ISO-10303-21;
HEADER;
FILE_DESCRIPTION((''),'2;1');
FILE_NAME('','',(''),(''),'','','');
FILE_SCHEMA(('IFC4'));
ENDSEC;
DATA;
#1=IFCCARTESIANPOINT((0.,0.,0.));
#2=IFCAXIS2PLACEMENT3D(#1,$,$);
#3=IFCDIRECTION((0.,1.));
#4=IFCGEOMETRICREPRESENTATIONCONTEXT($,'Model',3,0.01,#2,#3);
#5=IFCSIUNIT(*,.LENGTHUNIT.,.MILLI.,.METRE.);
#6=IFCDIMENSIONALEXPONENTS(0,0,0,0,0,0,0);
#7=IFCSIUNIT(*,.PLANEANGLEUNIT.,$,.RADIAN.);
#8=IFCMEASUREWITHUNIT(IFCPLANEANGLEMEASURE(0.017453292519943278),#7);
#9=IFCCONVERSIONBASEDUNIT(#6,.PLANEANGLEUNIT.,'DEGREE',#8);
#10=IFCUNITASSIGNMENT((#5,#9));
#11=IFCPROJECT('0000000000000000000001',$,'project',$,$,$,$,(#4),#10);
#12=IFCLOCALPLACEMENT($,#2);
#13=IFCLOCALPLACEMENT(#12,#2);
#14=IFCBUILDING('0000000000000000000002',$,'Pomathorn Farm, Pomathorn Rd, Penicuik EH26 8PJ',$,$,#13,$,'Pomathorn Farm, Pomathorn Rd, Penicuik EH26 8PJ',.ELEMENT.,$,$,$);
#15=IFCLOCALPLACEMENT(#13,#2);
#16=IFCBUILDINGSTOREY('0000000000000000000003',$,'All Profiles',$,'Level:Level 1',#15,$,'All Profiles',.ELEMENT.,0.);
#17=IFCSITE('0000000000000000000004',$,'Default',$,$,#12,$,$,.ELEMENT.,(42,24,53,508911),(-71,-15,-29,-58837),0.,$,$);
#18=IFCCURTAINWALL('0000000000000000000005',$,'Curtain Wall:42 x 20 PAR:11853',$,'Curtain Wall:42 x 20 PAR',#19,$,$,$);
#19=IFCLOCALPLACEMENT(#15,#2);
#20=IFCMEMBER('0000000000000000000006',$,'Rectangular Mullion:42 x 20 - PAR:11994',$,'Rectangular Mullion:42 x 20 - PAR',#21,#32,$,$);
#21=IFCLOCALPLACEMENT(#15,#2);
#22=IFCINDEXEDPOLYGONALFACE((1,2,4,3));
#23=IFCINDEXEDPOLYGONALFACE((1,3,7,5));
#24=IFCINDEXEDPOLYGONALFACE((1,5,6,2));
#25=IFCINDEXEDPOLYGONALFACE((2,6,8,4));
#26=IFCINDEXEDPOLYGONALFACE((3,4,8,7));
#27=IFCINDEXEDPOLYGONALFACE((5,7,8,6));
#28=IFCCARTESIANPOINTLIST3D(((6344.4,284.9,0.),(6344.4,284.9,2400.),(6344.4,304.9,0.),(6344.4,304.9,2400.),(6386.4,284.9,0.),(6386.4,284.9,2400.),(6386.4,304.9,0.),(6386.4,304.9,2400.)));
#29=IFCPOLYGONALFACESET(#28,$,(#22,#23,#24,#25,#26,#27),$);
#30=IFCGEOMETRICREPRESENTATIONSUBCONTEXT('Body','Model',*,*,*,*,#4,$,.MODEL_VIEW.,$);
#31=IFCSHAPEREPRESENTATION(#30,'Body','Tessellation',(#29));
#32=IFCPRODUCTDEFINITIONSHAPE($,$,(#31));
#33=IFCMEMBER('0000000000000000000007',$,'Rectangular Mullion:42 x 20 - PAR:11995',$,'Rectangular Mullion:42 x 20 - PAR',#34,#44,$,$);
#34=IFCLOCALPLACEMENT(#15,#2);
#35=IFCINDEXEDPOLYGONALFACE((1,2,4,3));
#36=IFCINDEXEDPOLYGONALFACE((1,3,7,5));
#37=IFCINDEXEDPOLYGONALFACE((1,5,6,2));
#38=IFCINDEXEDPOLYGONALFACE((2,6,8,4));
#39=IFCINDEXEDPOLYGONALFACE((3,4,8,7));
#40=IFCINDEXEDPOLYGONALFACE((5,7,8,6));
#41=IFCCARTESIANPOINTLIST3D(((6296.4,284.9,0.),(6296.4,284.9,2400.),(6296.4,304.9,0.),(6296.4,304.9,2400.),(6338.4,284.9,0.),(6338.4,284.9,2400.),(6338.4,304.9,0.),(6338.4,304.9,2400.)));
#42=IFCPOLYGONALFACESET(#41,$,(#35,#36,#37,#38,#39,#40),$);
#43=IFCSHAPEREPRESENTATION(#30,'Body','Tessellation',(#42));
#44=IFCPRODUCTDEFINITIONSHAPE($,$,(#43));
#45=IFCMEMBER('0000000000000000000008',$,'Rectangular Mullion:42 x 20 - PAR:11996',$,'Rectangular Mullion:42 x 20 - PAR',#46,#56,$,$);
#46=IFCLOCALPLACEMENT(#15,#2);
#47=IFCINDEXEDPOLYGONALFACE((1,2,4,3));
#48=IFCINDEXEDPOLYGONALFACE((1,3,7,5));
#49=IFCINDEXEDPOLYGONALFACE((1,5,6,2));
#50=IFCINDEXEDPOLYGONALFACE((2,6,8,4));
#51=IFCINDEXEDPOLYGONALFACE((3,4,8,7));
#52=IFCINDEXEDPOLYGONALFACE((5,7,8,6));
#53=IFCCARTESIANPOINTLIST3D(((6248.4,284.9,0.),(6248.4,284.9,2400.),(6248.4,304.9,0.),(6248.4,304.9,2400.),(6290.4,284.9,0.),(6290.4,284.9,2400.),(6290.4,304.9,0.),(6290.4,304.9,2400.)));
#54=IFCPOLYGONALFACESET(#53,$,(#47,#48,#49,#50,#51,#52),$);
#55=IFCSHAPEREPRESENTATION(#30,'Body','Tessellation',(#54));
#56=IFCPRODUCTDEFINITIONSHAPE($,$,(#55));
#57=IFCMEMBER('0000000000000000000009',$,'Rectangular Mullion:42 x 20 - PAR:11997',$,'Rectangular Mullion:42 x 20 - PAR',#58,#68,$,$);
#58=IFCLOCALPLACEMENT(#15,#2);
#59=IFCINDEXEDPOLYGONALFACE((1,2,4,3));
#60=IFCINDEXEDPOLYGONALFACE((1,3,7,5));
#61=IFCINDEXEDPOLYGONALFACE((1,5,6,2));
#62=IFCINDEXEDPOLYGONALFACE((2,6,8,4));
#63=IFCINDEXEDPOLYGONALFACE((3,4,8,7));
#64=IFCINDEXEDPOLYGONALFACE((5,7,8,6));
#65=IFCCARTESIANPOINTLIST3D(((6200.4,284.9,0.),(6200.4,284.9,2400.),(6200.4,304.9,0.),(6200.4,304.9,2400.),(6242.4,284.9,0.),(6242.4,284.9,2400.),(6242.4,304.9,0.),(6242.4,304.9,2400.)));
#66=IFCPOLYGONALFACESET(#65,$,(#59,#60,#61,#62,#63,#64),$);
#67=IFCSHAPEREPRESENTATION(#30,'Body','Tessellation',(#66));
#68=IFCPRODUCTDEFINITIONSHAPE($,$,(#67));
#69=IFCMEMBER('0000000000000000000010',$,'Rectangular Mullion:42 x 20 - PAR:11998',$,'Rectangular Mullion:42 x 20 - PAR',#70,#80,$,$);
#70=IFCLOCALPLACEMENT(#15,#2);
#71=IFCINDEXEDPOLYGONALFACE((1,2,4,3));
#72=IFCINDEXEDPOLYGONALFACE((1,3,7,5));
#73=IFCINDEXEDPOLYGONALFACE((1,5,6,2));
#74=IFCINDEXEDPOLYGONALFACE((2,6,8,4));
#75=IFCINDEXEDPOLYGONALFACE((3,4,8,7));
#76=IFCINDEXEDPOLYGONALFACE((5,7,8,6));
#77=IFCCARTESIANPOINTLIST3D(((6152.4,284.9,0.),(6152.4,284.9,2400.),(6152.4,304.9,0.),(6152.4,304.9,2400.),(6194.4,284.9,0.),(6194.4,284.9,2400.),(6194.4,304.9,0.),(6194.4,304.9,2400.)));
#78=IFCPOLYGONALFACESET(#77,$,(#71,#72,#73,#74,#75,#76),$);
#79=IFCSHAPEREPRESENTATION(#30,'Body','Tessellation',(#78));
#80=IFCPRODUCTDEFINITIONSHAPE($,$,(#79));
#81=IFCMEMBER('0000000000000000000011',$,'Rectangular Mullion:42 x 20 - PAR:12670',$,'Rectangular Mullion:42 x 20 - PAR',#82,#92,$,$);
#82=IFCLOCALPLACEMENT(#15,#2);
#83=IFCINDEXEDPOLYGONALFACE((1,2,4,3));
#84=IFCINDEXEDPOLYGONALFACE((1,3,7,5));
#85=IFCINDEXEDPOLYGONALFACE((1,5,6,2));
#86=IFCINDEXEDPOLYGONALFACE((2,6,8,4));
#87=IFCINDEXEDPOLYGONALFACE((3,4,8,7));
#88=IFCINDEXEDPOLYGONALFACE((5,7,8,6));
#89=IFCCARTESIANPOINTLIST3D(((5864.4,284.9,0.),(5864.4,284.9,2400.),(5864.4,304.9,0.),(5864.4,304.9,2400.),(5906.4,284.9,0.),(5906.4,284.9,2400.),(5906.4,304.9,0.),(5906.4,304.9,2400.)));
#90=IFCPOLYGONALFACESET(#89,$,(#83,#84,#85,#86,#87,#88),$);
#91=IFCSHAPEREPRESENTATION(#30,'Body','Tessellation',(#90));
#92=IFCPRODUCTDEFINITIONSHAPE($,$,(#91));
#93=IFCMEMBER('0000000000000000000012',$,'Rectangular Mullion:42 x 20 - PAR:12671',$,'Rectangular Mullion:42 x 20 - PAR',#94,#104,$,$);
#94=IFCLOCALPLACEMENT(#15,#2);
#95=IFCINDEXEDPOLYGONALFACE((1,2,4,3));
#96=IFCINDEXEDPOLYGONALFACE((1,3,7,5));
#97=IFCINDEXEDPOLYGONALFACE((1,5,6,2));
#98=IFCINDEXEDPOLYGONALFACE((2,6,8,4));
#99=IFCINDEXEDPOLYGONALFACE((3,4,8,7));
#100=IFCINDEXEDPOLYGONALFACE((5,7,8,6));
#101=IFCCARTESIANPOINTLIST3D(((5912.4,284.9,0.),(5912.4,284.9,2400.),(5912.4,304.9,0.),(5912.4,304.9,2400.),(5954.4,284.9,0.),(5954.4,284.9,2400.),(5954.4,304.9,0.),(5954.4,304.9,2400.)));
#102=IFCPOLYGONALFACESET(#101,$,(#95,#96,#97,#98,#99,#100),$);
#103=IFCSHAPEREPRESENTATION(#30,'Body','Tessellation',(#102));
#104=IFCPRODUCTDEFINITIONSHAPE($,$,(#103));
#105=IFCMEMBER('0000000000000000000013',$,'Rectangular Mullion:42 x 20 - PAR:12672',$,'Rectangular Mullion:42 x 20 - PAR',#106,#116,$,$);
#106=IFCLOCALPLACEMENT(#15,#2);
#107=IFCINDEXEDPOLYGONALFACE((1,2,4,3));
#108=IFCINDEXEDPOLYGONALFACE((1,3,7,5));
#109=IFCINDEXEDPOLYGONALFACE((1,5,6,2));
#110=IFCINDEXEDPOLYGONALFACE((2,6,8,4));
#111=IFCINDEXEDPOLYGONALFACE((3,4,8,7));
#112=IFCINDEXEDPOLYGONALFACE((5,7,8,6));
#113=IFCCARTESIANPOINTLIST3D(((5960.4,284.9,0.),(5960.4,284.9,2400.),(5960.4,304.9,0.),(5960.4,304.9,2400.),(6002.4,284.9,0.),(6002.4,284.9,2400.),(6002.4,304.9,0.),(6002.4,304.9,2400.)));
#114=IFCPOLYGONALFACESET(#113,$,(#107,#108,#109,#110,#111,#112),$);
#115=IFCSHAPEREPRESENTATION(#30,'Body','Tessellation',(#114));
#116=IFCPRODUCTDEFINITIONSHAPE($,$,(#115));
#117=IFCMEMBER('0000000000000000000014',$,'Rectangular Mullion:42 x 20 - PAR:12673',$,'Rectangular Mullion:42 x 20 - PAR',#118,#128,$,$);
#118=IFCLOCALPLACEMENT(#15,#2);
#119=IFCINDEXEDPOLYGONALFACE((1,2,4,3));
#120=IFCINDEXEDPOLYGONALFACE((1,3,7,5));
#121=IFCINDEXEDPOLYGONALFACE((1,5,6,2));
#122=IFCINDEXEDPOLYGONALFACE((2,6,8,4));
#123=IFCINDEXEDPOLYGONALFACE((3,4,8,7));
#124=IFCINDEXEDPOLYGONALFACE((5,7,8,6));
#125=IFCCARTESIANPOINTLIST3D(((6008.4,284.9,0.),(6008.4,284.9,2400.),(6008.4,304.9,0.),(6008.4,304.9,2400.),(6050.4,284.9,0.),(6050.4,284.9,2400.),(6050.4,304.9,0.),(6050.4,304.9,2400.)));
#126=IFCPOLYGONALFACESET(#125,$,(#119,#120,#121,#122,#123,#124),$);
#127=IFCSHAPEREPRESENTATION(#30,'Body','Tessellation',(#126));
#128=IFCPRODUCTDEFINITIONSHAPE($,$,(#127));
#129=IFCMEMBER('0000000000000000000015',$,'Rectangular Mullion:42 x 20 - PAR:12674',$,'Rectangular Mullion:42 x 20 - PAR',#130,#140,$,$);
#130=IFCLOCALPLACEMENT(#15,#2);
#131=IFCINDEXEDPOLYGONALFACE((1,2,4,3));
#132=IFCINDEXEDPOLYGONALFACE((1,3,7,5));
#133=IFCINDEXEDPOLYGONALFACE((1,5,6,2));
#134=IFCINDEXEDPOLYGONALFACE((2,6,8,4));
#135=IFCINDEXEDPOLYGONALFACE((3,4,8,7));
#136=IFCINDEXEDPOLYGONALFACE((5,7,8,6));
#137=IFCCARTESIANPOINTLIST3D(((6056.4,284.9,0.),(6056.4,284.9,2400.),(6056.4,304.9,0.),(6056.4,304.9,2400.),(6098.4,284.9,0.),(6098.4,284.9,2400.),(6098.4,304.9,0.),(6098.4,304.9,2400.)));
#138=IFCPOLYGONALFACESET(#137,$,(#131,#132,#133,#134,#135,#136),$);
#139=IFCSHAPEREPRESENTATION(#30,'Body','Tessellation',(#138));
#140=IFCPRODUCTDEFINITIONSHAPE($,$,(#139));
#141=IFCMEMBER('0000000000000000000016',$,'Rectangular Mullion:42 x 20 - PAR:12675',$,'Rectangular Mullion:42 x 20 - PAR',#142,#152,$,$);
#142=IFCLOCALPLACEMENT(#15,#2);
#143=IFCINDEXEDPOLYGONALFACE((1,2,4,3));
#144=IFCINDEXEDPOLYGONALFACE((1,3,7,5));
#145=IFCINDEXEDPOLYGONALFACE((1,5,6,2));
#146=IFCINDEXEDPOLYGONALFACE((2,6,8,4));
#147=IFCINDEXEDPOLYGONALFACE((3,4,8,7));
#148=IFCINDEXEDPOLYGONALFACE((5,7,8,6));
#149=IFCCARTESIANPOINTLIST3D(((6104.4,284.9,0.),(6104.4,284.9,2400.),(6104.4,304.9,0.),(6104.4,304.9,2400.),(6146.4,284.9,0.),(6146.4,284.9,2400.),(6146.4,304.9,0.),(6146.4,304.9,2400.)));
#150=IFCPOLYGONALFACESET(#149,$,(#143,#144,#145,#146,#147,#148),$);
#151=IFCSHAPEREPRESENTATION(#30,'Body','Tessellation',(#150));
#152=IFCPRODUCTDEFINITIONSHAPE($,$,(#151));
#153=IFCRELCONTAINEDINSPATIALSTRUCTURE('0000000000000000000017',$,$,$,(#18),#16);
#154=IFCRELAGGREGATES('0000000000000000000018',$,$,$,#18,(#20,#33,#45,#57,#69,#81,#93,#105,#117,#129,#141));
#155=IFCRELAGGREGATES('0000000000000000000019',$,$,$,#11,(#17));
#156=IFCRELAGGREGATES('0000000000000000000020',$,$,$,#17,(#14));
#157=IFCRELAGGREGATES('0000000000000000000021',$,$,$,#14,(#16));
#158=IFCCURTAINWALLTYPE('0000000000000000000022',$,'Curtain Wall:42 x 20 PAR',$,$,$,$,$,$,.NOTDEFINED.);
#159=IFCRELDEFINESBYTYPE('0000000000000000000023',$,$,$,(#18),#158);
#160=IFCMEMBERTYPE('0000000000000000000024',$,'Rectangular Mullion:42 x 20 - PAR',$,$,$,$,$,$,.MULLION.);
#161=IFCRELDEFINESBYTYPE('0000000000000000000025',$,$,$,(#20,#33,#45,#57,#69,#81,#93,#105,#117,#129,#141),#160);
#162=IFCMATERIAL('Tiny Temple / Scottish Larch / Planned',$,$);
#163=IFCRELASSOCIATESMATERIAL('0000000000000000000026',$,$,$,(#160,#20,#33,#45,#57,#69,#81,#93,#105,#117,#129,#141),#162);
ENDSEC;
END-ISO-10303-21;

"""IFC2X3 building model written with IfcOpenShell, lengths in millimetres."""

from ifc_helpers import new_model, entity, si_unit, converted_unit, direction, frame, frame_2d, origin, place, context, subcontext, project, spatial, rectangle, extrude, source, transform, mapped, material, type_object, type_shapes, element, aggregate, save


model = new_model("IFC2X3")

# Units and contexts
model_context = context("Model", 3, precision=0.01, world=origin(), true_north=direction((0.0, 1.0)))
body_context = subcontext(model_context, "Body", "Model", "MODEL_VIEW")
ifc_project = project(units=[si_unit("LENGTHUNIT", "METRE", prefix="MILLI"), converted_unit("PLANEANGLEUNIT", "DEGREE", entity("IfcPlaneAngleMeasure", 0.017453292519943278), si_unit("PLANEANGLEUNIT", "RADIAN"), dimensions=[0, 0, 0, 0, 0, 0, 0])], contexts=[model_context])

# Site, building, storey
site_placement = place(None, origin())
site = spatial("IfcSite", under=ifc_project, at=site_placement, Name="Default", CompositionType="ELEMENT", RefLatitude=(42, 24, 53, 508911), RefLongitude=(-71, -15, -29, -58837), RefElevation=0.0)
building_placement = place(site_placement, origin())
building = spatial("IfcBuilding", under=site, at=building_placement, Name="Pomathorn Farm, Pomathorn Rd, Penicuik EH26 8PJ", LongName="Pomathorn Farm, Pomathorn Rd, Penicuik EH26 8PJ", CompositionType="ELEMENT")
storey_placement = place(building_placement, origin())
storey = spatial("IfcBuildingStorey", under=building, at=storey_placement, Name="All Profiles", ObjectType="Level:Level 1", LongName="All Profiles", CompositionType="ELEMENT", Elevation=0.0)

# Curtain wall, members
curtain_wall_type = type_object("IfcCurtainWallType", Name="Curtain Wall:42 x 20 PAR", PredefinedType="NOTDEFINED")
curtain_wall_placement = place(storey_placement, origin())
curtain_wall = element("IfcCurtainWall", 1, at=curtain_wall_placement, inside=storey, type_object=curtain_wall_type, Name="Curtain Wall:42 x 20 PAR:11853", ObjectType="Curtain Wall:42 x 20 PAR")
ifc_material = material(Name="Tiny Temple / Scottish Larch / Planned")
member_type = type_object("IfcMemberType", Name="Rectangular Mullion:42 x 20 - PAR", PredefinedType="MULLION", material=ifc_material)
shared_shape = source(origin(), body_context, "Body", "SweptSolid", [
    extrude(rectangle(XDim=20.0, YDim=42.0, at=frame_2d((0.0, 0.0), x_axis=(1.0, 0.0))), frame((-21.0, -10.0, -2400.0), z_axis=(0.0, 0.0, 1.0), x_axis=(0.0, 1.0, 0.0)), (0.0, 0.0, 1.0), 2400.0),
])
type_shapes(member_type, [shared_shape])
member_1_placement = place(curtain_wall_placement, frame((6386.4, 284.9, 0.0), z_axis=(0.0, 0.0, -1.0), x_axis=(1.0, 0.0, 0.0)))
member_1 = element("IfcMember", 2, at=member_1_placement, type_object=member_type, material=ifc_material, Name="Rectangular Mullion:42 x 20 - PAR:11994", ObjectType="Rectangular Mullion:42 x 20 - PAR", context=body_context, shape_type="MappedRepresentation", body=[
    mapped(shared_shape, transform((0.0, 0.0, 0.0), scale=1.0)),
])
member_2_placement = place(curtain_wall_placement, frame((6338.4, 284.9, 0.0), z_axis=(0.0, 0.0, -1.0), x_axis=(1.0, 0.0, 0.0)))
member_2 = element("IfcMember", 3, at=member_2_placement, type_object=member_type, material=ifc_material, Name="Rectangular Mullion:42 x 20 - PAR:11995", ObjectType="Rectangular Mullion:42 x 20 - PAR", context=body_context, shape_type="MappedRepresentation", body=[
    mapped(shared_shape, transform((0.0, 0.0, 0.0), scale=1.0)),
])
member_3_placement = place(curtain_wall_placement, frame((6290.4, 284.9, 0.0), z_axis=(0.0, 0.0, -1.0), x_axis=(1.0, 0.0, 0.0)))
member_3 = element("IfcMember", 4, at=member_3_placement, type_object=member_type, material=ifc_material, Name="Rectangular Mullion:42 x 20 - PAR:11996", ObjectType="Rectangular Mullion:42 x 20 - PAR", context=body_context, shape_type="MappedRepresentation", body=[
    mapped(shared_shape, transform((0.0, 0.0, 0.0), scale=1.0)),
])
member_4_placement = place(curtain_wall_placement, frame((6242.4, 284.9, 0.0), z_axis=(0.0, 0.0, -1.0), x_axis=(1.0, 0.0, 0.0)))
member_4 = element("IfcMember", 5, at=member_4_placement, type_object=member_type, material=ifc_material, Name="Rectangular Mullion:42 x 20 - PAR:11997", ObjectType="Rectangular Mullion:42 x 20 - PAR", context=body_context, shape_type="MappedRepresentation", body=[
    mapped(shared_shape, transform((0.0, 0.0, 0.0), scale=1.0)),
])
member_5_placement = place(curtain_wall_placement, frame((6194.4, 284.9, 0.0), z_axis=(0.0, 0.0, -1.0), x_axis=(1.0, 0.0, 0.0)))
member_5 = element("IfcMember", 6, at=member_5_placement, type_object=member_type, material=ifc_material, Name="Rectangular Mullion:42 x 20 - PAR:11998", ObjectType="Rectangular Mullion:42 x 20 - PAR", context=body_context, shape_type="MappedRepresentation", body=[
    mapped(shared_shape, transform((0.0, 0.0, 0.0), scale=1.0)),
])
member_6_placement = place(curtain_wall_placement, frame((5906.4, 284.9, 0.0), z_axis=(0.0, 0.0, -1.0), x_axis=(1.0, 0.0, 0.0)))
member_6 = element("IfcMember", 7, at=member_6_placement, type_object=member_type, material=ifc_material, Name="Rectangular Mullion:42 x 20 - PAR:12670", ObjectType="Rectangular Mullion:42 x 20 - PAR", context=body_context, shape_type="MappedRepresentation", body=[
    mapped(shared_shape, transform((0.0, 0.0, 0.0), scale=1.0)),
])
member_7_placement = place(curtain_wall_placement, frame((5954.4, 284.9, 0.0), z_axis=(0.0, 0.0, -1.0), x_axis=(1.0, 0.0, 0.0)))
member_7 = element("IfcMember", 8, at=member_7_placement, type_object=member_type, material=ifc_material, Name="Rectangular Mullion:42 x 20 - PAR:12671", ObjectType="Rectangular Mullion:42 x 20 - PAR", context=body_context, shape_type="MappedRepresentation", body=[
    mapped(shared_shape, transform((0.0, 0.0, 0.0), scale=1.0)),
])
member_8_placement = place(curtain_wall_placement, frame((6002.4, 284.9, 0.0), z_axis=(0.0, 0.0, -1.0), x_axis=(1.0, 0.0, 0.0)))
member_8 = element("IfcMember", 9, at=member_8_placement, type_object=member_type, material=ifc_material, Name="Rectangular Mullion:42 x 20 - PAR:12672", ObjectType="Rectangular Mullion:42 x 20 - PAR", context=body_context, shape_type="MappedRepresentation", body=[
    mapped(shared_shape, transform((0.0, 0.0, 0.0), scale=1.0)),
])
member_9_placement = place(curtain_wall_placement, frame((6050.4, 284.9, 0.0), z_axis=(0.0, 0.0, -1.0), x_axis=(1.0, 0.0, 0.0)))
member_9 = element("IfcMember", 10, at=member_9_placement, type_object=member_type, material=ifc_material, Name="Rectangular Mullion:42 x 20 - PAR:12673", ObjectType="Rectangular Mullion:42 x 20 - PAR", context=body_context, shape_type="MappedRepresentation", body=[
    mapped(shared_shape, transform((0.0, 0.0, 0.0), scale=1.0)),
])
member_10_placement = place(curtain_wall_placement, frame((6098.4, 284.9, 0.0), z_axis=(0.0, 0.0, -1.0), x_axis=(1.0, 0.0, 0.0)))
member_10 = element("IfcMember", 11, at=member_10_placement, type_object=member_type, material=ifc_material, Name="Rectangular Mullion:42 x 20 - PAR:12674", ObjectType="Rectangular Mullion:42 x 20 - PAR", context=body_context, shape_type="MappedRepresentation", body=[
    mapped(shared_shape, transform((0.0, 0.0, 0.0), scale=1.0)),
])
member_11_placement = place(curtain_wall_placement, frame((6146.4, 284.9, 0.0), z_axis=(0.0, 0.0, -1.0), x_axis=(1.0, 0.0, 0.0)))
member_11 = element("IfcMember", 12, at=member_11_placement, type_object=member_type, material=ifc_material, Name="Rectangular Mullion:42 x 20 - PAR:12675", ObjectType="Rectangular Mullion:42 x 20 - PAR", context=body_context, shape_type="MappedRepresentation", body=[
    mapped(shared_shape, transform((0.0, 0.0, 0.0), scale=1.0)),
])
aggregate(curtain_wall, [member_1, member_2, member_3, member_4, member_5, member_6, member_7, member_8, member_9, member_10, member_11])

save(model, "model.ifc")
